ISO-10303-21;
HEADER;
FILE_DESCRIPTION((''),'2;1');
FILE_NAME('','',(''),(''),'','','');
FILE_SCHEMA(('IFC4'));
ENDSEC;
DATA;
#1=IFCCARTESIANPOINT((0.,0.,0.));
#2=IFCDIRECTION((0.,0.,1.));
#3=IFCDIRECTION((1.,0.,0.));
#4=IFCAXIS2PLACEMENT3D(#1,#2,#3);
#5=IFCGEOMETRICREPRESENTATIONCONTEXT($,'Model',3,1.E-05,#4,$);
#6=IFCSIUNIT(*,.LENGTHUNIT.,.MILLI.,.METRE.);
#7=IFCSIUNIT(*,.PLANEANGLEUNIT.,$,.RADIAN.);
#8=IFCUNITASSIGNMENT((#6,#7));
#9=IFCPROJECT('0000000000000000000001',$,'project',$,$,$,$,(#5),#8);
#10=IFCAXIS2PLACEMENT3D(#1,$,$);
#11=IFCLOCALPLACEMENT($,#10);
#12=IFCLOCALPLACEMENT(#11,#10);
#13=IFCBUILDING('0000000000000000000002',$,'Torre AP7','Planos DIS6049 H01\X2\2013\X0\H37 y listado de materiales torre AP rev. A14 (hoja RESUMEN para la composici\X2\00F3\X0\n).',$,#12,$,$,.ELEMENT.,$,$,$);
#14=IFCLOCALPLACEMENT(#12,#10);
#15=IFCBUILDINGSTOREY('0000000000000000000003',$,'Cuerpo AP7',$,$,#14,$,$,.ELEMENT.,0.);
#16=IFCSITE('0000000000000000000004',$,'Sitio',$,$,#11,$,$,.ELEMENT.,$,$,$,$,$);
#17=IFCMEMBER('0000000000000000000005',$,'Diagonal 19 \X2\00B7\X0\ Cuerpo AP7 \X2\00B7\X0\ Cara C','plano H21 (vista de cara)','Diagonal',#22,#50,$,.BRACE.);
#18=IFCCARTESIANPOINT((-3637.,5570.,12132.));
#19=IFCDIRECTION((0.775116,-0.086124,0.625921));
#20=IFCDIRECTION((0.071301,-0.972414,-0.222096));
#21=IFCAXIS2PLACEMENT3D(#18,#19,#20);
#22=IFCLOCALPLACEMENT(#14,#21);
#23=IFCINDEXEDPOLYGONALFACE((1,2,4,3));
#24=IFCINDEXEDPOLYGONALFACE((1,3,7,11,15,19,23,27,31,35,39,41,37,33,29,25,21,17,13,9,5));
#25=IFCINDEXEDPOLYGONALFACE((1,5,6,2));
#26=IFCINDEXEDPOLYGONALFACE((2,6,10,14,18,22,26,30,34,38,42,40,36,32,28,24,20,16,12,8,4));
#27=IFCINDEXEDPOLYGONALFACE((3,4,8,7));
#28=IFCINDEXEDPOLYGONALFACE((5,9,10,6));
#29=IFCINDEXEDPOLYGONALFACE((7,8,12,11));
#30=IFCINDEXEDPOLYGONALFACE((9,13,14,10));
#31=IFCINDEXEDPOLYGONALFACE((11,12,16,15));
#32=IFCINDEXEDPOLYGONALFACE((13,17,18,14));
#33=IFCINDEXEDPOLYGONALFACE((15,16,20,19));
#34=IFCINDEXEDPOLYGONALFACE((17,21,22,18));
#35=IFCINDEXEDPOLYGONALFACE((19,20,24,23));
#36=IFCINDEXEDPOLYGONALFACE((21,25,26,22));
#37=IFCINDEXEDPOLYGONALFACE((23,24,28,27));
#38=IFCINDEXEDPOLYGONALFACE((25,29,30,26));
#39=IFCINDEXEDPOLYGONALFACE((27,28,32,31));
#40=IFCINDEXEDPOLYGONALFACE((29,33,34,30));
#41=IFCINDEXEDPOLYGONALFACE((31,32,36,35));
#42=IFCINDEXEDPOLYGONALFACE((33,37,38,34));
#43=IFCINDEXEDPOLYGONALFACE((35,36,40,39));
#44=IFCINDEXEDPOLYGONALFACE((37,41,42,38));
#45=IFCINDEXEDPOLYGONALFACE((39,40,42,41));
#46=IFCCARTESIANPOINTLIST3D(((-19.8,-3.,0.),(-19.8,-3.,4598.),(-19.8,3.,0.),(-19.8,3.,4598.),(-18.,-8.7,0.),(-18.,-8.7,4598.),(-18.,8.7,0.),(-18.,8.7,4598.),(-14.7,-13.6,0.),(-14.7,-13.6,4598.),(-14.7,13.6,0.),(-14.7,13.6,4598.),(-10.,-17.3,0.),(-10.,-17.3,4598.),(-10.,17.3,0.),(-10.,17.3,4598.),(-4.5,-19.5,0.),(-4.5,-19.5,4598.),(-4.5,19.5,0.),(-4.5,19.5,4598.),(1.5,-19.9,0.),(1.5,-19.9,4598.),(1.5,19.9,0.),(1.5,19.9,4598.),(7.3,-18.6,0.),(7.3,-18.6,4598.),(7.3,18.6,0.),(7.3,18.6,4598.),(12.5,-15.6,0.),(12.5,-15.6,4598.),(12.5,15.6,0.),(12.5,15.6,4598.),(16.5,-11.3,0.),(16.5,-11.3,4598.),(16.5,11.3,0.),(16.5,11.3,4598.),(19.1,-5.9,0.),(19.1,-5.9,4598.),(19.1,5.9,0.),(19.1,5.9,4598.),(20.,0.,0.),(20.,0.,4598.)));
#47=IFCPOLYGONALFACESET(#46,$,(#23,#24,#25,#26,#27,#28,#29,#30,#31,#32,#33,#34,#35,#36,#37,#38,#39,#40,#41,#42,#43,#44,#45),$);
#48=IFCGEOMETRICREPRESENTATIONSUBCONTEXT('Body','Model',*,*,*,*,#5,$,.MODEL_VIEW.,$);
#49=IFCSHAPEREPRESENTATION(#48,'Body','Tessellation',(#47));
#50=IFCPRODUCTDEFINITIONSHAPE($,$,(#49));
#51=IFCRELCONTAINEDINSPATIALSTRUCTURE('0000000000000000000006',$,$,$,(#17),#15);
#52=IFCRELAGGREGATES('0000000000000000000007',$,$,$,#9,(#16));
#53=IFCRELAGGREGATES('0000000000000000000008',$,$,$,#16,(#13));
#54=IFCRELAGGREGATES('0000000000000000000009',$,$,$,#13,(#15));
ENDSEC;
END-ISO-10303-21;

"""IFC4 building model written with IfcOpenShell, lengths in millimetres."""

from ifc_helpers import new_model, si_unit, frame, origin, origin_with_axes, place, context, subcontext, project, spatial, circle, extrude, element, save


model = new_model("IFC4")

# Units and contexts
model_context = context("Model", 3, precision=1e-05, world=origin_with_axes())
body_context = subcontext(model_context, "Body", "Model", "MODEL_VIEW")
ifc_project = project(units=[si_unit("LENGTHUNIT", "METRE", prefix="MILLI"), si_unit("PLANEANGLEUNIT", "RADIAN")], contexts=[model_context])

# Site, building, storey
site_placement = place(None, origin())
site = spatial("IfcSite", under=ifc_project, at=site_placement, Name="Sitio", CompositionType="ELEMENT")
building_placement = place(site_placement, origin())
building = spatial("IfcBuilding", under=site, at=building_placement, Name="Torre AP7", Description="Planos DIS6049 H01–H37 y listado de materiales torre AP rev. A14 (hoja RESUMEN para la composición).", CompositionType="ELEMENT")
storey_placement = place(building_placement, origin())
storey = spatial("IfcBuildingStorey", under=building, at=storey_placement, Name="Cuerpo AP7", CompositionType="ELEMENT", Elevation=0.0)

# Member
member_1_placement = place(storey_placement, frame((-3637.0, 5570.0, 12132.0), z_axis=(0.775116, -0.086124, 0.625921), x_axis=(0.071301, -0.972414, -0.222096)))
element("IfcMember", 1, at=member_1_placement, inside=storey, Name="Diagonal 19 · Cuerpo AP7 · Cara C", Description="plano H21 (vista de cara)", ObjectType="Diagonal", PredefinedType="BRACE", context=body_context, shape_type="SweptSolid", body=[
    extrude(circle(Radius=20.0), None, (0.0, 0.0, 1.0), 4598.0),
])

save(model, "model.ifc")
